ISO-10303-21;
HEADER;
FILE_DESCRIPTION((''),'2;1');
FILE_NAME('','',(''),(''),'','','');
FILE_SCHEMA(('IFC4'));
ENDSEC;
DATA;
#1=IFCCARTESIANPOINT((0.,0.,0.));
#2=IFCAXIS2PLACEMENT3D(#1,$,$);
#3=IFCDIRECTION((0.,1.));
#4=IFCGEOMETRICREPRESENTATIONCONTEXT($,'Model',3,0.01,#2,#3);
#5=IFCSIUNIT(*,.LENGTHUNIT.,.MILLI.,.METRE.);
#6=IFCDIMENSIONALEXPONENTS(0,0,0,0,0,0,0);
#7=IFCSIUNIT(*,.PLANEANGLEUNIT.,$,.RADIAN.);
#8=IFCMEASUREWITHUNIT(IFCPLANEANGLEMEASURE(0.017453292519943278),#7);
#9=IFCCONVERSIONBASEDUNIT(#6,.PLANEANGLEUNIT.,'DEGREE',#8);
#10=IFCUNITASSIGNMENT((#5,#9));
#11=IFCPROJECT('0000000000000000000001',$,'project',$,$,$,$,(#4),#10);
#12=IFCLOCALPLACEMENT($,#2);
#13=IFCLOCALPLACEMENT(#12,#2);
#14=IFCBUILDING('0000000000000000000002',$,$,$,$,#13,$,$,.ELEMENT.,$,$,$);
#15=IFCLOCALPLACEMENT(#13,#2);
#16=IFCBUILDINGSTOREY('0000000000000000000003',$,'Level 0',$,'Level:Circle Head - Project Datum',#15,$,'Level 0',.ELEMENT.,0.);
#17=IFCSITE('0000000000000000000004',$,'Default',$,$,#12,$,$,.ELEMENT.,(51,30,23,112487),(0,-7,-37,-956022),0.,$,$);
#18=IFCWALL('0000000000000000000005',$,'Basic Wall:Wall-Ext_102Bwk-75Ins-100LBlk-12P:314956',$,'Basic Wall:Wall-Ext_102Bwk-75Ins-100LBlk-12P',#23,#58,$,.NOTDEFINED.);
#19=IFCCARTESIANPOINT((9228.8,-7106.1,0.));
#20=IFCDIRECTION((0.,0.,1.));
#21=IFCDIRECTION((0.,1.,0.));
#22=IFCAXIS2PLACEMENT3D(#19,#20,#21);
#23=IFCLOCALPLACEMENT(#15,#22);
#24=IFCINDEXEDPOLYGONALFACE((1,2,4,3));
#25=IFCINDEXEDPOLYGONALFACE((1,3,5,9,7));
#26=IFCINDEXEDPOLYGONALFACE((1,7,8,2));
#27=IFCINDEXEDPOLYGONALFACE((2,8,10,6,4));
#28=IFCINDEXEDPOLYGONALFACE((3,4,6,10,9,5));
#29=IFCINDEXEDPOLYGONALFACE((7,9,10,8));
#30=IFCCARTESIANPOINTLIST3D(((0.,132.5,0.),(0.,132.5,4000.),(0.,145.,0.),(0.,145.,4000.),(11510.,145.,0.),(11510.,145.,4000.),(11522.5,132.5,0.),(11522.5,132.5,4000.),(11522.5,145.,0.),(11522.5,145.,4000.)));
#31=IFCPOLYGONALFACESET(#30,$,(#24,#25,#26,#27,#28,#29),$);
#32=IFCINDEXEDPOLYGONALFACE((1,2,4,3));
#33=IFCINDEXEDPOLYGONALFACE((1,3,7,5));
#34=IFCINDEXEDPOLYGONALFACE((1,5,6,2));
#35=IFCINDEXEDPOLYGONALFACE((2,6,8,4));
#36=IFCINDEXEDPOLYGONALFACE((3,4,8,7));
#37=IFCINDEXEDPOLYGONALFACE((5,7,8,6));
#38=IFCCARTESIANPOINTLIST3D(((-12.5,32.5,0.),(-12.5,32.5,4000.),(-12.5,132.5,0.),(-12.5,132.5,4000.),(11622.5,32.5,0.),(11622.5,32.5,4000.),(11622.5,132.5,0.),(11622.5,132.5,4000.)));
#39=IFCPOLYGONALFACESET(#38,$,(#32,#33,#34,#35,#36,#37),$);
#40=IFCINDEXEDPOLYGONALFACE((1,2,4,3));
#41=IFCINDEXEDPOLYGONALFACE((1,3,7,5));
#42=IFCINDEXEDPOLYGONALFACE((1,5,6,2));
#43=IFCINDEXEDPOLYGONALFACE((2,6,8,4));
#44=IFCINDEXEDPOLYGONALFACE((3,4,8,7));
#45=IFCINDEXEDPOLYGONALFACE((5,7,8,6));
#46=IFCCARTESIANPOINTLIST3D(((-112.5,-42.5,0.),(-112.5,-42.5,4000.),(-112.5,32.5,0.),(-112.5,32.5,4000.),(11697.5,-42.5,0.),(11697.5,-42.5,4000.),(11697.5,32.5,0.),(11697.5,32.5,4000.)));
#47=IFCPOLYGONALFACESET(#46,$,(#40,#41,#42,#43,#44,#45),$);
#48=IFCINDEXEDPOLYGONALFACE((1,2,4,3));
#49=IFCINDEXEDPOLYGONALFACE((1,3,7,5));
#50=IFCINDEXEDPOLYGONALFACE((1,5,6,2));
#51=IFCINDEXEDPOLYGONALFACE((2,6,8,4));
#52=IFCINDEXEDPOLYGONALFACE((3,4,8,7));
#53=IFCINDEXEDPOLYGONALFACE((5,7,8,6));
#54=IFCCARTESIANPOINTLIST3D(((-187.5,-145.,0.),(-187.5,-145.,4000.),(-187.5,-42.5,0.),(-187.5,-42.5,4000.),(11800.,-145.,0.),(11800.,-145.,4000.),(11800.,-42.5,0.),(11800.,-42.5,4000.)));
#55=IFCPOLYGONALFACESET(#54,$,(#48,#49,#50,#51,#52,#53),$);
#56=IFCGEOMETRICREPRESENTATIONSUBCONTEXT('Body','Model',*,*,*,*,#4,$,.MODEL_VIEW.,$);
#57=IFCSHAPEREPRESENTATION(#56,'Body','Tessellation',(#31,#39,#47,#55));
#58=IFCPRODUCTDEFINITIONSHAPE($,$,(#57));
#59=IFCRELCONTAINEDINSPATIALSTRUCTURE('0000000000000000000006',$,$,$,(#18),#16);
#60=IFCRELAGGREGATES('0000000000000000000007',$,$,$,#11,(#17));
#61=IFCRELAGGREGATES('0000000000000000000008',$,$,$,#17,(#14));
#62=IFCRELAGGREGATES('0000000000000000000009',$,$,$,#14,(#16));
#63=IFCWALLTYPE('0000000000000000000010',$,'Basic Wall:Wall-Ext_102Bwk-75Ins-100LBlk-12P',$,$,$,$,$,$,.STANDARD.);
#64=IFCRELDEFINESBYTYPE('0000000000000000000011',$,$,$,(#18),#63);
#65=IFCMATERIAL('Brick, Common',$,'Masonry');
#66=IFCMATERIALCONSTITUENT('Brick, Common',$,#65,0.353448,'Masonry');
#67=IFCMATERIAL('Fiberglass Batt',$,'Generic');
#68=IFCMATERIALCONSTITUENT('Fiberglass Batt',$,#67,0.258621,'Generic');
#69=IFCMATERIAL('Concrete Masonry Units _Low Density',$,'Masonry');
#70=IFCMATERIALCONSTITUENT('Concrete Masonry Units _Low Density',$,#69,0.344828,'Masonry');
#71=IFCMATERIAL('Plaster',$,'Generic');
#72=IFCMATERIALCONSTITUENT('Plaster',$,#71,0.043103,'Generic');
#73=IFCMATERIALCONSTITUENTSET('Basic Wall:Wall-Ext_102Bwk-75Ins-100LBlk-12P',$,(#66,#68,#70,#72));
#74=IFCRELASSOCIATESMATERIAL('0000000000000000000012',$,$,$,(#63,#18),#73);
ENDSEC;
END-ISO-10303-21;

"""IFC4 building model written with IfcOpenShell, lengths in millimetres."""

from ifc_helpers import new_model, entity, si_unit, converted_unit, direction, frame, origin, place, context, subcontext, project, spatial, indexed_curve, outline, extrude, material, constituent, constituent_set, type_object, element, save


model = new_model("IFC4")

# Units and contexts
model_context = context("Model", 3, precision=0.01, world=origin(), true_north=direction((0.0, 1.0)))
body_context = subcontext(model_context, "Body", "Model", "MODEL_VIEW")
ifc_project = project(units=[si_unit("LENGTHUNIT", "METRE", prefix="MILLI"), converted_unit("PLANEANGLEUNIT", "DEGREE", entity("IfcPlaneAngleMeasure", 0.017453292519943278), si_unit("PLANEANGLEUNIT", "RADIAN"), dimensions=[0, 0, 0, 0, 0, 0, 0])], contexts=[model_context])

# Site, building, storey
site_placement = place(None, origin())
site = spatial("IfcSite", under=ifc_project, at=site_placement, Name="Default", CompositionType="ELEMENT", RefLatitude=(51, 30, 23, 112487), RefLongitude=(0, -7, -37, -956022), RefElevation=0.0)
building_placement = place(site_placement, origin())
building = spatial("IfcBuilding", under=site, at=building_placement, CompositionType="ELEMENT")
storey_placement = place(building_placement, origin())
storey = spatial("IfcBuildingStorey", under=building, at=storey_placement, Name="Level 0", ObjectType="Level:Circle Head - Project Datum", LongName="Level 0", CompositionType="ELEMENT", Elevation=0.0)

# Shared definitions
ifc_material_1 = material(Name="Plaster", Category="Generic")

# Shared definitions
ifc_material_2 = material(Name="Brick, Common", Category="Masonry")
ifc_constituent_1 = constituent(ifc_material_2, Name="Brick, Common", Category="Masonry", fraction=0.353448)
ifc_material_3 = material(Name="Fiberglass Batt", Category="Generic")
ifc_constituent_2 = constituent(ifc_material_3, Name="Fiberglass Batt", Category="Generic", fraction=0.258621)
ifc_material_4 = material(Name="Concrete Masonry Units _Low Density", Category="Masonry")
ifc_constituent_3 = constituent(ifc_material_4, Name="Concrete Masonry Units _Low Density", Category="Masonry", fraction=0.344828)
ifc_constituent_4 = constituent(ifc_material_1, Name="Plaster", Category="Generic", fraction=0.043103)
ifc_constituent_set_1 = constituent_set(constituents=[ifc_constituent_1, ifc_constituent_2, ifc_constituent_3, ifc_constituent_4], Name="Basic Wall:Wall-Ext_102Bwk-75Ins-100LBlk-12P")
wall_type_1 = type_object("IfcWallType", Name="Basic Wall:Wall-Ext_102Bwk-75Ins-100LBlk-12P", PredefinedType="STANDARD", material=ifc_constituent_set_1)

# Wall
wall_1_placement = place(storey_placement, frame((9228.8, -7106.1, 0.0), z_axis=(0.0, 0.0, 1.0), x_axis=(0.0, 1.0, 0.0)))
element("IfcWall", 1, at=wall_1_placement, inside=storey, type_object=wall_type_1, material=ifc_constituent_set_1, Name="Basic Wall:Wall-Ext_102Bwk-75Ins-100LBlk-12P:314956", ObjectType="Basic Wall:Wall-Ext_102Bwk-75Ins-100LBlk-12P", PredefinedType="NOTDEFINED", context=body_context, shape_type="SweptSolid", body=[
    extrude(outline(indexed_curve([(-4599.0, -5.0), (6911.0, -5.0), (6911.0, 7.5), (-4611.5, 7.5), (-4611.5, -5.0), (-4599.0, -5.0)], self_intersect=False)), frame((6911.0, 140.0, 0.0), z_axis=(0.0, 0.0, 1.0), x_axis=(-1.0, 0.0, 0.0)), (0.0, 0.0, 1.0), 4000.0),
    extrude(outline(indexed_curve([(-5817.5, -50.0), (5817.5, -50.0), (5817.5, 50.0), (-5817.5, 50.0), (-5817.5, -50.0)], self_intersect=False)), frame((5805.0, 82.5, 0.0)), (0.0, 0.0, 1.0), 4000.0),
    extrude(outline(indexed_curve([(-5905.0, -37.5), (5905.0, -37.5), (5905.0, 37.5), (-5905.0, 37.5), (-5905.0, -37.5)], self_intersect=False)), frame((5792.5, -5.0, 0.0)), (0.0, 0.0, 1.0), 4000.0),
    extrude(outline(indexed_curve([(-51.3, -5993.7), (51.2, -5993.7), (51.3, 5993.7), (-51.2, 5993.7), (-51.3, -5993.7)], self_intersect=False)), frame((5806.2, -93.8, 0.0), z_axis=(0.0, 0.0, 1.0), x_axis=(0.0, 1.0, 0.0)), (0.0, 0.0, 1.0), 4000.0),
])

save(model, "model.ifc")
